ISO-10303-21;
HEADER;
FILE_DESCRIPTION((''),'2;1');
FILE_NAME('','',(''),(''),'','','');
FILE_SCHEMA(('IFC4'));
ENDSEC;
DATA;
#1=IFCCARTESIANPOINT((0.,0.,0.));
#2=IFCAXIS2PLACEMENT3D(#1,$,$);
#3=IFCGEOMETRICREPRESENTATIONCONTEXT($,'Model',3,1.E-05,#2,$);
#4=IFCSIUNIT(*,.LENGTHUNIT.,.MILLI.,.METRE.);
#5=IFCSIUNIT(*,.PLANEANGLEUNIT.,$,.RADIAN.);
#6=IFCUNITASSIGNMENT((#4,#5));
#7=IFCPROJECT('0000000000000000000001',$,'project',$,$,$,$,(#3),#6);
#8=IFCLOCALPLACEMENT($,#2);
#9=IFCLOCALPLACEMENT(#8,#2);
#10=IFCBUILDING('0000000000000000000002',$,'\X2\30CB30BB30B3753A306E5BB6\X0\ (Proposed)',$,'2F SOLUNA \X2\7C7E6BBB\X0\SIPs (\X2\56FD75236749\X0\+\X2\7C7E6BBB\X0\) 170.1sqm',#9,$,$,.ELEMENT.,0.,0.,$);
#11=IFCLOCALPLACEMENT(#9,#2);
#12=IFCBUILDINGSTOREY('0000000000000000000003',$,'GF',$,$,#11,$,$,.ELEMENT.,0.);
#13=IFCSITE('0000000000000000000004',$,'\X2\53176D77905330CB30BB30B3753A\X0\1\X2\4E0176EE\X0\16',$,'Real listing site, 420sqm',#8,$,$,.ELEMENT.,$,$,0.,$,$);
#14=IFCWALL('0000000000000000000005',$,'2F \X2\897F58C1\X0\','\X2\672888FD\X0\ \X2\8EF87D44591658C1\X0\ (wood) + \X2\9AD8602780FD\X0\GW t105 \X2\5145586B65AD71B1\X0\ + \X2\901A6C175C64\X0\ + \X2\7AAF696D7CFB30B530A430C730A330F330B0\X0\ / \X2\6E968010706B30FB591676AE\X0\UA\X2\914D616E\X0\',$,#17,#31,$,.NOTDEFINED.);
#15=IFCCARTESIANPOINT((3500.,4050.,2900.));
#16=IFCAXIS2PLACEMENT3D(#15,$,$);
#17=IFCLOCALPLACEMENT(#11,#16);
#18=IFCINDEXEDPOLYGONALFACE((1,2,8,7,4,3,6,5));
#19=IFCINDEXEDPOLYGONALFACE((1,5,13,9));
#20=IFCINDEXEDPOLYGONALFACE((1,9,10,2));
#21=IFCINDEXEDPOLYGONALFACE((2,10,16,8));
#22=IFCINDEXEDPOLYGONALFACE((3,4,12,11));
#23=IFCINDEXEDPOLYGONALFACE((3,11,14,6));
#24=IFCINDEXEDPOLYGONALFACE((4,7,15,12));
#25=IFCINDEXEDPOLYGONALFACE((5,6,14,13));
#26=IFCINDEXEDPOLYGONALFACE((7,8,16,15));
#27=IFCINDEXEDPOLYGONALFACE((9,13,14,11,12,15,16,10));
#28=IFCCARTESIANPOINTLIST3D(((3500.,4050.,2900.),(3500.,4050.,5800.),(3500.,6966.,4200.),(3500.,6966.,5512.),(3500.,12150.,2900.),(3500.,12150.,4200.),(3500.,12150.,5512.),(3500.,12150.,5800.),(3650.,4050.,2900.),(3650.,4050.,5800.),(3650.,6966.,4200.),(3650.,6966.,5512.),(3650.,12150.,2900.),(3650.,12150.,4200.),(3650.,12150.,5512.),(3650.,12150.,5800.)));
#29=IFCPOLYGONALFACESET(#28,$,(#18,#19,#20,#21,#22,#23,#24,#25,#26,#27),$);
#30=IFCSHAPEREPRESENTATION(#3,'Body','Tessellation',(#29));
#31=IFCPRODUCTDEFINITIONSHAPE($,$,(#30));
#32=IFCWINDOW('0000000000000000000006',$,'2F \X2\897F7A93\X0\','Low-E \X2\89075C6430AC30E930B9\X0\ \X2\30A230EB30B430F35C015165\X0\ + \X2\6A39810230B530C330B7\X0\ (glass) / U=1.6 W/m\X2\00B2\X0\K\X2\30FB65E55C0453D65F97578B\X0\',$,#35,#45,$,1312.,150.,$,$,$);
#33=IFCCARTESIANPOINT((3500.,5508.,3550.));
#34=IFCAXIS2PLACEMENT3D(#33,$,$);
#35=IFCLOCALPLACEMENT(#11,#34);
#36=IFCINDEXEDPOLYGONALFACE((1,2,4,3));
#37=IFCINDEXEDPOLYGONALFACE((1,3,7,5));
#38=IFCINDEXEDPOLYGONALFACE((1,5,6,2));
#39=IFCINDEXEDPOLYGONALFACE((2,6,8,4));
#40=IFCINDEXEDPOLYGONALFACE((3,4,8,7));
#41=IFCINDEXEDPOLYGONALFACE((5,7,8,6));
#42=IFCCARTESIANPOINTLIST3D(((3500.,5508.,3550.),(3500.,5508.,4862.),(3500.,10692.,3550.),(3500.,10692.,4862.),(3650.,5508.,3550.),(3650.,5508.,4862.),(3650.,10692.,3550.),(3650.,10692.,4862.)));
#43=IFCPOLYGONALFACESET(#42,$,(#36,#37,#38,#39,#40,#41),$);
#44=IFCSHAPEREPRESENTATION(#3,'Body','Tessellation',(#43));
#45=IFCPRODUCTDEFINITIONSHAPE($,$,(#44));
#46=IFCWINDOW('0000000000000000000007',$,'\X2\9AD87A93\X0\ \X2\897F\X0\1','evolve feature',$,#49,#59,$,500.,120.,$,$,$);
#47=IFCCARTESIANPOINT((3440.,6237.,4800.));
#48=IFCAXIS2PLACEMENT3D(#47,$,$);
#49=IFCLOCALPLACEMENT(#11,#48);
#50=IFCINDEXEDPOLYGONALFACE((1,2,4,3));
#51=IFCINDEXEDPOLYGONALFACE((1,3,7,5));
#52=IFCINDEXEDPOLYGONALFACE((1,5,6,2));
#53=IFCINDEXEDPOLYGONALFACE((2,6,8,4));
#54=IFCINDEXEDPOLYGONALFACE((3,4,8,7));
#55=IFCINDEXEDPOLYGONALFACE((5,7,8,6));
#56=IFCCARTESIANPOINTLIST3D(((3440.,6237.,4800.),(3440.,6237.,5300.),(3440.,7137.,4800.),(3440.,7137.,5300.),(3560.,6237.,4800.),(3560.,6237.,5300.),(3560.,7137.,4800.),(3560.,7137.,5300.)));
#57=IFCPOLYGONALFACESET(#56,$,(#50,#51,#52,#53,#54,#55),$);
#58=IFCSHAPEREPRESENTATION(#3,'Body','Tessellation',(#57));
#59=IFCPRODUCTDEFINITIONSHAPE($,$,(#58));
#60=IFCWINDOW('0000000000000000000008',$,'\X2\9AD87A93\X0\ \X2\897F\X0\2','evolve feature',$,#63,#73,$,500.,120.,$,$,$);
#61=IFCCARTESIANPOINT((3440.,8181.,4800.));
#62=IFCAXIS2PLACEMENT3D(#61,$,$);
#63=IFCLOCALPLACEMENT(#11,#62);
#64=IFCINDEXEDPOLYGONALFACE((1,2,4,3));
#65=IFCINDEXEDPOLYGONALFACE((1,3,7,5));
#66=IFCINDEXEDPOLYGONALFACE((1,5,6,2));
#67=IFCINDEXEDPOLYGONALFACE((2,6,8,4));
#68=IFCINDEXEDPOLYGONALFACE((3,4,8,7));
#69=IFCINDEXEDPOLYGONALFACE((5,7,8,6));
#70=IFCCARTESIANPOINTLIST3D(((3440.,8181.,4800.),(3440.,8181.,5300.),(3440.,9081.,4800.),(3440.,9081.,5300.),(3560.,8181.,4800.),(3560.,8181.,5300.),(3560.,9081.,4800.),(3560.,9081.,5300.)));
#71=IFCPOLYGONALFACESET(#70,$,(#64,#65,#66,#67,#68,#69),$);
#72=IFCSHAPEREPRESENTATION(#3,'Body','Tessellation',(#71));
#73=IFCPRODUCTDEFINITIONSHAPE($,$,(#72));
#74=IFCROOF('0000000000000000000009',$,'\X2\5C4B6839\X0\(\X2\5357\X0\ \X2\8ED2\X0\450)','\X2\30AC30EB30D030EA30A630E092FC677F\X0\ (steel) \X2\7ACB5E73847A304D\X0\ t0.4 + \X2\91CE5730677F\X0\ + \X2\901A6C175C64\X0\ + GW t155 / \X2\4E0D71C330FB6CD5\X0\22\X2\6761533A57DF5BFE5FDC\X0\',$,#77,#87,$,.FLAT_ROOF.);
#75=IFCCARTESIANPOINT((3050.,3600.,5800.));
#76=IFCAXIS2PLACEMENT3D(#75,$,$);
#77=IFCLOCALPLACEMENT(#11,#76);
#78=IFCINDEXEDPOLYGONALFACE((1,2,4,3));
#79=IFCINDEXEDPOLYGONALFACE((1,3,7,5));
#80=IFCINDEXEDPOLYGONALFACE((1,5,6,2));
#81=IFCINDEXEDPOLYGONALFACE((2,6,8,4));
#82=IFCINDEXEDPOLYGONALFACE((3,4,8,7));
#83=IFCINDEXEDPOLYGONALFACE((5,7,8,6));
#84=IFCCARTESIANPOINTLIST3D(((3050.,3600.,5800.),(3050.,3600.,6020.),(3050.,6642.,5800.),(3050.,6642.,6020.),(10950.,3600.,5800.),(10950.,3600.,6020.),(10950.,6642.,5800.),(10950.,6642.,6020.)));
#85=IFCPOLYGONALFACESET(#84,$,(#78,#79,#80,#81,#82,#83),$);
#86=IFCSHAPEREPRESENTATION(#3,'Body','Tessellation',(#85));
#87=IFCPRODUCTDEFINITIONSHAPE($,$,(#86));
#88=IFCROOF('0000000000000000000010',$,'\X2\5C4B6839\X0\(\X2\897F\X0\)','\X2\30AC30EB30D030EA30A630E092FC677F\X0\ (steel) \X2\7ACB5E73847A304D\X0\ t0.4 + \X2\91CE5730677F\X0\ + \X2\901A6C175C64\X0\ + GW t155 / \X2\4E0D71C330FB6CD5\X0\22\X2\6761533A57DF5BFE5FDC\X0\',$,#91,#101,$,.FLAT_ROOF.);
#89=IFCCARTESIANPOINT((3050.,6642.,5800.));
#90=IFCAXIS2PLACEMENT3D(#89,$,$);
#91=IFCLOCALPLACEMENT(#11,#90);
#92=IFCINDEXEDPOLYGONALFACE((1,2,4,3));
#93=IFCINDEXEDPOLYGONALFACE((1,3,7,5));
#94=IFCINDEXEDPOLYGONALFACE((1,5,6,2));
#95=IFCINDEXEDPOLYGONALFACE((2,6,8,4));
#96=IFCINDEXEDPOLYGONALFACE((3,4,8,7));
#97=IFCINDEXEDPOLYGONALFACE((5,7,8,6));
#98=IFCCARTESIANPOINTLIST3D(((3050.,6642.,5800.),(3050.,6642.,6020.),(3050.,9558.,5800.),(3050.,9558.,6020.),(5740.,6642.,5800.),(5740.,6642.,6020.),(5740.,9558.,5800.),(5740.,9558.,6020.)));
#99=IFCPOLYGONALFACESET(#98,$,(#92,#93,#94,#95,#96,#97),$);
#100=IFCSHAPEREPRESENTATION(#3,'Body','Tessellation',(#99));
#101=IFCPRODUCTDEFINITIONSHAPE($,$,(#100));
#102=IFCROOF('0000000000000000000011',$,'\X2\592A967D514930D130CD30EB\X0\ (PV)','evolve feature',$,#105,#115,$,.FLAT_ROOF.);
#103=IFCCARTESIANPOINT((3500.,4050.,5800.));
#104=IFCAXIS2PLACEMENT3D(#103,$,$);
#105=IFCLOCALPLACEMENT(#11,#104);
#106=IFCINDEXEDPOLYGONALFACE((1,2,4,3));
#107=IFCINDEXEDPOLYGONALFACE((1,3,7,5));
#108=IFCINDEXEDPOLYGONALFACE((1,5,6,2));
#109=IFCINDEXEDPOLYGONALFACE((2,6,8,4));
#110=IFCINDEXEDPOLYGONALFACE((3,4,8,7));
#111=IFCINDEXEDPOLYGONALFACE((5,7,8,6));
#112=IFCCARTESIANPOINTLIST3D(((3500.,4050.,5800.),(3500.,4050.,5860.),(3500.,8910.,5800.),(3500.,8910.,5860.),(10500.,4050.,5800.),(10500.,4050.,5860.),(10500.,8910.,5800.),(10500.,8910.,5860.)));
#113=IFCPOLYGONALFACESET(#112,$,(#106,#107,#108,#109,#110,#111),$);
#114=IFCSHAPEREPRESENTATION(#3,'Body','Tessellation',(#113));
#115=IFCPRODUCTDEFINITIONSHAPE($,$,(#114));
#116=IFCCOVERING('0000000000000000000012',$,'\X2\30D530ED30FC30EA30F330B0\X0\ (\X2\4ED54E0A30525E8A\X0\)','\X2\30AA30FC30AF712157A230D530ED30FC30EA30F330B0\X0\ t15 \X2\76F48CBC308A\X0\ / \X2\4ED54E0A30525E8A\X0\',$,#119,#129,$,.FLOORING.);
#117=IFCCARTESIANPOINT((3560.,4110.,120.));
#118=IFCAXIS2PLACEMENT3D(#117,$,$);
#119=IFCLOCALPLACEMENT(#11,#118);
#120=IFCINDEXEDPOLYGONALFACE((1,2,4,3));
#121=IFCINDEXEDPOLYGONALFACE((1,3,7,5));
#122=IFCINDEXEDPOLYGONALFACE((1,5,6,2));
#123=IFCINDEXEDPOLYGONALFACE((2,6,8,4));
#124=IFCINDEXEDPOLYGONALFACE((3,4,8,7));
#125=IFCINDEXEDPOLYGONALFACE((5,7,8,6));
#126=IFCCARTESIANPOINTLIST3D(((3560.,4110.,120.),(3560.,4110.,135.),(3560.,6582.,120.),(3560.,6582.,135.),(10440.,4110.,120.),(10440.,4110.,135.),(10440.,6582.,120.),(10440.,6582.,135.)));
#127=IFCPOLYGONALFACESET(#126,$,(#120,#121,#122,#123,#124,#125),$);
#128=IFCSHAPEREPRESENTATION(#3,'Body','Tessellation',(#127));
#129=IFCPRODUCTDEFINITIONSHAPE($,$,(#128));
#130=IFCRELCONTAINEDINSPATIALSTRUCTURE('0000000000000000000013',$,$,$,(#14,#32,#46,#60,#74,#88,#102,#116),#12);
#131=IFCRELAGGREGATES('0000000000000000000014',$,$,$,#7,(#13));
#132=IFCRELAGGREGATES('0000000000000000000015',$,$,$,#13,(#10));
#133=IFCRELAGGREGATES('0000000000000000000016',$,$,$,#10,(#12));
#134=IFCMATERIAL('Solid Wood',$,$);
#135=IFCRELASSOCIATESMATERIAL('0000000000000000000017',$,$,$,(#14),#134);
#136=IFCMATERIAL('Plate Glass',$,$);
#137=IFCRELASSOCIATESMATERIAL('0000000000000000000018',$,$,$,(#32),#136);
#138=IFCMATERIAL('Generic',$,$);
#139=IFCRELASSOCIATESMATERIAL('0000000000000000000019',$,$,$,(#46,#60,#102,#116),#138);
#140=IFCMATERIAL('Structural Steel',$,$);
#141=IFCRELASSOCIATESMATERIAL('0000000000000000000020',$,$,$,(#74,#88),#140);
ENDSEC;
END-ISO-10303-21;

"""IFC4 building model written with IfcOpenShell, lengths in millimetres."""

from ifc_helpers import new_model, si_unit, frame, frame_2d, origin, place, context, project, spatial, rectangle, extrude, material, element, fill, save


model = new_model("IFC4")

# Units and contexts
model_context = context("Model", 3, precision=1e-05, world=origin())
ifc_project = project(units=[si_unit("LENGTHUNIT", "METRE", prefix="MILLI"), si_unit("PLANEANGLEUNIT", "RADIAN")], contexts=[model_context])

# Site, building, storey
site_placement = place(None, origin())
site = spatial("IfcSite", under=ifc_project, at=site_placement, Name="北海道ニセコ町1丁目16", ObjectType="Real listing site, 420sqm", CompositionType="ELEMENT", RefElevation=0.0)
building_placement = place(site_placement, origin())
building = spatial("IfcBuilding", under=site, at=building_placement, Name="ニセコ町の家 (Proposed)", ObjectType="2F SOLUNA 籾殻SIPs (国産杉+籾殻) 170.1sqm", CompositionType="ELEMENT", ElevationOfRefHeight=0.0, ElevationOfTerrain=0.0)
storey_placement = place(building_placement, origin())
storey = spatial("IfcBuildingStorey", under=building, at=storey_placement, Name="GF", CompositionType="ELEMENT", Elevation=0.0)

# Shared definitions
ifc_material_1 = material(Name="Solid Wood")
ifc_material_2 = material(Name="Generic")

# Shared definitions
ifc_material_3 = material(Name="Plate Glass")

# Wall, openings, windows
wall_1_placement = place(storey_placement, frame((3500.0, 4050.0, 2900.0)))
wall_1 = element("IfcWall", 1, at=wall_1_placement, inside=storey, material=ifc_material_1, Name="2F 西壁", Description="木製 軸組外壁 (wood) + 高性能GW t105 充填断熱 + 通気層 + 窯業系サイディング / 準耐火・外皮UA配慮", PredefinedType="NOTDEFINED", context=model_context, shape_type="SweptSolid", body=[
    extrude(rectangle(XDim=150.0, YDim=8100.0, at=frame_2d((75.0, 4050.0))), frame((3500.0, 4050.0, 2900.0)), (0.0, 0.0, 1.0), 2900.0),
])
opening_1_placement = place(storey_placement, frame((3500.0, 5508.0, 3550.0)))
opening_1 = element("IfcOpeningElement", 2, at=opening_1_placement, cuts=wall_1, PredefinedType="NOTDEFINED", context=model_context, shape_type="SweptSolid", body=[
    extrude(rectangle(XDim=150.0, YDim=5184.0, at=frame_2d((75.0, 2592.0))), frame((3500.0, 5508.0, 3550.0)), (0.0, 0.0, 1.0), 1312.0),
])
opening_2_placement = place(storey_placement, frame((3440.0, 6237.0, 4800.0)))
opening_2 = element("IfcOpeningElement", 3, at=opening_2_placement, cuts=wall_1, PredefinedType="NOTDEFINED", context=model_context, shape_type="SweptSolid", body=[
    extrude(rectangle(XDim=120.0, YDim=900.0, at=frame_2d((60.0, 450.0))), frame((3440.0, 6237.0, 4800.0)), (0.0, 0.0, 1.0), 500.0),
])
opening_3_placement = place(storey_placement, frame((3440.0, 8181.0, 4800.0)))
opening_3 = element("IfcOpeningElement", 4, at=opening_3_placement, cuts=wall_1, PredefinedType="NOTDEFINED", context=model_context, shape_type="SweptSolid", body=[
    extrude(rectangle(XDim=120.0, YDim=900.0, at=frame_2d((60.0, 450.0))), frame((3440.0, 8181.0, 4800.0)), (0.0, 0.0, 1.0), 500.0),
])
window_1_placement = place(storey_placement, frame((3500.0, 5508.0, 3550.0)))
window_1 = element("IfcWindow", 5, at=window_1_placement, inside=storey, material=ifc_material_3, Name="2F 西窓", Description="Low-E 複層ガラス アルゴン封入 + 樹脂サッシ (glass) / U=1.6 W/m²K・日射取得型", OverallHeight=1312.0, OverallWidth=150.0, context=model_context, shape_type="SweptSolid", body=[
    extrude(rectangle(XDim=150.0, YDim=5184.0, at=frame_2d((75.0, 2592.0))), frame((3500.0, 5508.0, 3550.0)), (0.0, 0.0, 1.0), 1312.0),
])
fill(opening_1, window_1)
window_2_placement = place(storey_placement, frame((3440.0, 6237.0, 4800.0)))
window_2 = element("IfcWindow", 6, at=window_2_placement, inside=storey, material=ifc_material_2, Name="高窓 西1", Description="evolve feature", OverallHeight=500.0, OverallWidth=120.0, context=model_context, shape_type="SweptSolid", body=[
    extrude(rectangle(XDim=120.0, YDim=900.0, at=frame_2d((60.0, 450.0))), frame((3440.0, 6237.0, 4800.0)), (0.0, 0.0, 1.0), 500.0),
])
fill(opening_2, window_2)
window_3_placement = place(storey_placement, frame((3440.0, 8181.0, 4800.0)))
window_3 = element("IfcWindow", 7, at=window_3_placement, inside=storey, material=ifc_material_2, Name="高窓 西2", Description="evolve feature", OverallHeight=500.0, OverallWidth=120.0, context=model_context, shape_type="SweptSolid", body=[
    extrude(rectangle(XDim=120.0, YDim=900.0, at=frame_2d((60.0, 450.0))), frame((3440.0, 8181.0, 4800.0)), (0.0, 0.0, 1.0), 500.0),
])
fill(opening_3, window_3)

# Roofs
ifc_material_4 = material(Name="Structural Steel")
roof_1_placement = place(storey_placement, frame((3050.0, 3600.0, 5800.0)))
element("IfcRoof", 8, at=roof_1_placement, inside=storey, material=ifc_material_4, Name="屋根(南 軒450)", Description="ガルバリウム鋼板 (steel) 立平葺き t0.4 + 野地板 + 通気層 + GW t155 / 不燃・法22条区域対応", PredefinedType="FLAT_ROOF", context=model_context, shape_type="SweptSolid", body=[
    extrude(rectangle(XDim=7900.0, YDim=3042.0, at=frame_2d((3950.0, 1521.0))), frame((3050.0, 3600.0, 5800.0)), (0.0, 0.0, 1.0), 220.0),
])
roof_2_placement = place(storey_placement, frame((3050.0, 6642.0, 5800.0)))
element("IfcRoof", 9, at=roof_2_placement, inside=storey, material=ifc_material_4, Name="屋根(西)", Description="ガルバリウム鋼板 (steel) 立平葺き t0.4 + 野地板 + 通気層 + GW t155 / 不燃・法22条区域対応", PredefinedType="FLAT_ROOF", context=model_context, shape_type="SweptSolid", body=[
    extrude(rectangle(XDim=2690.0, YDim=2916.0, at=frame_2d((1345.0, 1458.0))), frame((3050.0, 6642.0, 5800.0)), (0.0, 0.0, 1.0), 220.0),
])
roof_3_placement = place(storey_placement, frame((3500.0, 4050.0, 5800.0)))
element("IfcRoof", 10, at=roof_3_placement, inside=storey, material=ifc_material_2, Name="太陽光パネル (PV)", Description="evolve feature", PredefinedType="FLAT_ROOF", context=model_context, shape_type="SweptSolid", body=[
    extrude(rectangle(XDim=7000.0, YDim=4860.0, at=frame_2d((3500.0, 2430.0))), frame((3500.0, 4050.0, 5800.0)), (0.0, 0.0, 1.0), 60.0),
])

# Covering
covering_placement = place(storey_placement, frame((3560.0, 4110.0, 120.0)))
element("IfcCovering", 11, at=covering_placement, inside=storey, material=ifc_material_2, Name="フローリング (仕上げ床)", Description="オーク無垢フローリング t15 直貼り / 仕上げ床", PredefinedType="FLOORING", context=model_context, shape_type="SweptSolid", body=[
    extrude(rectangle(XDim=6880.0, YDim=2472.0, at=frame_2d((3440.0, 1236.0))), frame((3560.0, 4110.0, 120.0)), (0.0, 0.0, 1.0), 15.0),
])

save(model, "model.ifc")
